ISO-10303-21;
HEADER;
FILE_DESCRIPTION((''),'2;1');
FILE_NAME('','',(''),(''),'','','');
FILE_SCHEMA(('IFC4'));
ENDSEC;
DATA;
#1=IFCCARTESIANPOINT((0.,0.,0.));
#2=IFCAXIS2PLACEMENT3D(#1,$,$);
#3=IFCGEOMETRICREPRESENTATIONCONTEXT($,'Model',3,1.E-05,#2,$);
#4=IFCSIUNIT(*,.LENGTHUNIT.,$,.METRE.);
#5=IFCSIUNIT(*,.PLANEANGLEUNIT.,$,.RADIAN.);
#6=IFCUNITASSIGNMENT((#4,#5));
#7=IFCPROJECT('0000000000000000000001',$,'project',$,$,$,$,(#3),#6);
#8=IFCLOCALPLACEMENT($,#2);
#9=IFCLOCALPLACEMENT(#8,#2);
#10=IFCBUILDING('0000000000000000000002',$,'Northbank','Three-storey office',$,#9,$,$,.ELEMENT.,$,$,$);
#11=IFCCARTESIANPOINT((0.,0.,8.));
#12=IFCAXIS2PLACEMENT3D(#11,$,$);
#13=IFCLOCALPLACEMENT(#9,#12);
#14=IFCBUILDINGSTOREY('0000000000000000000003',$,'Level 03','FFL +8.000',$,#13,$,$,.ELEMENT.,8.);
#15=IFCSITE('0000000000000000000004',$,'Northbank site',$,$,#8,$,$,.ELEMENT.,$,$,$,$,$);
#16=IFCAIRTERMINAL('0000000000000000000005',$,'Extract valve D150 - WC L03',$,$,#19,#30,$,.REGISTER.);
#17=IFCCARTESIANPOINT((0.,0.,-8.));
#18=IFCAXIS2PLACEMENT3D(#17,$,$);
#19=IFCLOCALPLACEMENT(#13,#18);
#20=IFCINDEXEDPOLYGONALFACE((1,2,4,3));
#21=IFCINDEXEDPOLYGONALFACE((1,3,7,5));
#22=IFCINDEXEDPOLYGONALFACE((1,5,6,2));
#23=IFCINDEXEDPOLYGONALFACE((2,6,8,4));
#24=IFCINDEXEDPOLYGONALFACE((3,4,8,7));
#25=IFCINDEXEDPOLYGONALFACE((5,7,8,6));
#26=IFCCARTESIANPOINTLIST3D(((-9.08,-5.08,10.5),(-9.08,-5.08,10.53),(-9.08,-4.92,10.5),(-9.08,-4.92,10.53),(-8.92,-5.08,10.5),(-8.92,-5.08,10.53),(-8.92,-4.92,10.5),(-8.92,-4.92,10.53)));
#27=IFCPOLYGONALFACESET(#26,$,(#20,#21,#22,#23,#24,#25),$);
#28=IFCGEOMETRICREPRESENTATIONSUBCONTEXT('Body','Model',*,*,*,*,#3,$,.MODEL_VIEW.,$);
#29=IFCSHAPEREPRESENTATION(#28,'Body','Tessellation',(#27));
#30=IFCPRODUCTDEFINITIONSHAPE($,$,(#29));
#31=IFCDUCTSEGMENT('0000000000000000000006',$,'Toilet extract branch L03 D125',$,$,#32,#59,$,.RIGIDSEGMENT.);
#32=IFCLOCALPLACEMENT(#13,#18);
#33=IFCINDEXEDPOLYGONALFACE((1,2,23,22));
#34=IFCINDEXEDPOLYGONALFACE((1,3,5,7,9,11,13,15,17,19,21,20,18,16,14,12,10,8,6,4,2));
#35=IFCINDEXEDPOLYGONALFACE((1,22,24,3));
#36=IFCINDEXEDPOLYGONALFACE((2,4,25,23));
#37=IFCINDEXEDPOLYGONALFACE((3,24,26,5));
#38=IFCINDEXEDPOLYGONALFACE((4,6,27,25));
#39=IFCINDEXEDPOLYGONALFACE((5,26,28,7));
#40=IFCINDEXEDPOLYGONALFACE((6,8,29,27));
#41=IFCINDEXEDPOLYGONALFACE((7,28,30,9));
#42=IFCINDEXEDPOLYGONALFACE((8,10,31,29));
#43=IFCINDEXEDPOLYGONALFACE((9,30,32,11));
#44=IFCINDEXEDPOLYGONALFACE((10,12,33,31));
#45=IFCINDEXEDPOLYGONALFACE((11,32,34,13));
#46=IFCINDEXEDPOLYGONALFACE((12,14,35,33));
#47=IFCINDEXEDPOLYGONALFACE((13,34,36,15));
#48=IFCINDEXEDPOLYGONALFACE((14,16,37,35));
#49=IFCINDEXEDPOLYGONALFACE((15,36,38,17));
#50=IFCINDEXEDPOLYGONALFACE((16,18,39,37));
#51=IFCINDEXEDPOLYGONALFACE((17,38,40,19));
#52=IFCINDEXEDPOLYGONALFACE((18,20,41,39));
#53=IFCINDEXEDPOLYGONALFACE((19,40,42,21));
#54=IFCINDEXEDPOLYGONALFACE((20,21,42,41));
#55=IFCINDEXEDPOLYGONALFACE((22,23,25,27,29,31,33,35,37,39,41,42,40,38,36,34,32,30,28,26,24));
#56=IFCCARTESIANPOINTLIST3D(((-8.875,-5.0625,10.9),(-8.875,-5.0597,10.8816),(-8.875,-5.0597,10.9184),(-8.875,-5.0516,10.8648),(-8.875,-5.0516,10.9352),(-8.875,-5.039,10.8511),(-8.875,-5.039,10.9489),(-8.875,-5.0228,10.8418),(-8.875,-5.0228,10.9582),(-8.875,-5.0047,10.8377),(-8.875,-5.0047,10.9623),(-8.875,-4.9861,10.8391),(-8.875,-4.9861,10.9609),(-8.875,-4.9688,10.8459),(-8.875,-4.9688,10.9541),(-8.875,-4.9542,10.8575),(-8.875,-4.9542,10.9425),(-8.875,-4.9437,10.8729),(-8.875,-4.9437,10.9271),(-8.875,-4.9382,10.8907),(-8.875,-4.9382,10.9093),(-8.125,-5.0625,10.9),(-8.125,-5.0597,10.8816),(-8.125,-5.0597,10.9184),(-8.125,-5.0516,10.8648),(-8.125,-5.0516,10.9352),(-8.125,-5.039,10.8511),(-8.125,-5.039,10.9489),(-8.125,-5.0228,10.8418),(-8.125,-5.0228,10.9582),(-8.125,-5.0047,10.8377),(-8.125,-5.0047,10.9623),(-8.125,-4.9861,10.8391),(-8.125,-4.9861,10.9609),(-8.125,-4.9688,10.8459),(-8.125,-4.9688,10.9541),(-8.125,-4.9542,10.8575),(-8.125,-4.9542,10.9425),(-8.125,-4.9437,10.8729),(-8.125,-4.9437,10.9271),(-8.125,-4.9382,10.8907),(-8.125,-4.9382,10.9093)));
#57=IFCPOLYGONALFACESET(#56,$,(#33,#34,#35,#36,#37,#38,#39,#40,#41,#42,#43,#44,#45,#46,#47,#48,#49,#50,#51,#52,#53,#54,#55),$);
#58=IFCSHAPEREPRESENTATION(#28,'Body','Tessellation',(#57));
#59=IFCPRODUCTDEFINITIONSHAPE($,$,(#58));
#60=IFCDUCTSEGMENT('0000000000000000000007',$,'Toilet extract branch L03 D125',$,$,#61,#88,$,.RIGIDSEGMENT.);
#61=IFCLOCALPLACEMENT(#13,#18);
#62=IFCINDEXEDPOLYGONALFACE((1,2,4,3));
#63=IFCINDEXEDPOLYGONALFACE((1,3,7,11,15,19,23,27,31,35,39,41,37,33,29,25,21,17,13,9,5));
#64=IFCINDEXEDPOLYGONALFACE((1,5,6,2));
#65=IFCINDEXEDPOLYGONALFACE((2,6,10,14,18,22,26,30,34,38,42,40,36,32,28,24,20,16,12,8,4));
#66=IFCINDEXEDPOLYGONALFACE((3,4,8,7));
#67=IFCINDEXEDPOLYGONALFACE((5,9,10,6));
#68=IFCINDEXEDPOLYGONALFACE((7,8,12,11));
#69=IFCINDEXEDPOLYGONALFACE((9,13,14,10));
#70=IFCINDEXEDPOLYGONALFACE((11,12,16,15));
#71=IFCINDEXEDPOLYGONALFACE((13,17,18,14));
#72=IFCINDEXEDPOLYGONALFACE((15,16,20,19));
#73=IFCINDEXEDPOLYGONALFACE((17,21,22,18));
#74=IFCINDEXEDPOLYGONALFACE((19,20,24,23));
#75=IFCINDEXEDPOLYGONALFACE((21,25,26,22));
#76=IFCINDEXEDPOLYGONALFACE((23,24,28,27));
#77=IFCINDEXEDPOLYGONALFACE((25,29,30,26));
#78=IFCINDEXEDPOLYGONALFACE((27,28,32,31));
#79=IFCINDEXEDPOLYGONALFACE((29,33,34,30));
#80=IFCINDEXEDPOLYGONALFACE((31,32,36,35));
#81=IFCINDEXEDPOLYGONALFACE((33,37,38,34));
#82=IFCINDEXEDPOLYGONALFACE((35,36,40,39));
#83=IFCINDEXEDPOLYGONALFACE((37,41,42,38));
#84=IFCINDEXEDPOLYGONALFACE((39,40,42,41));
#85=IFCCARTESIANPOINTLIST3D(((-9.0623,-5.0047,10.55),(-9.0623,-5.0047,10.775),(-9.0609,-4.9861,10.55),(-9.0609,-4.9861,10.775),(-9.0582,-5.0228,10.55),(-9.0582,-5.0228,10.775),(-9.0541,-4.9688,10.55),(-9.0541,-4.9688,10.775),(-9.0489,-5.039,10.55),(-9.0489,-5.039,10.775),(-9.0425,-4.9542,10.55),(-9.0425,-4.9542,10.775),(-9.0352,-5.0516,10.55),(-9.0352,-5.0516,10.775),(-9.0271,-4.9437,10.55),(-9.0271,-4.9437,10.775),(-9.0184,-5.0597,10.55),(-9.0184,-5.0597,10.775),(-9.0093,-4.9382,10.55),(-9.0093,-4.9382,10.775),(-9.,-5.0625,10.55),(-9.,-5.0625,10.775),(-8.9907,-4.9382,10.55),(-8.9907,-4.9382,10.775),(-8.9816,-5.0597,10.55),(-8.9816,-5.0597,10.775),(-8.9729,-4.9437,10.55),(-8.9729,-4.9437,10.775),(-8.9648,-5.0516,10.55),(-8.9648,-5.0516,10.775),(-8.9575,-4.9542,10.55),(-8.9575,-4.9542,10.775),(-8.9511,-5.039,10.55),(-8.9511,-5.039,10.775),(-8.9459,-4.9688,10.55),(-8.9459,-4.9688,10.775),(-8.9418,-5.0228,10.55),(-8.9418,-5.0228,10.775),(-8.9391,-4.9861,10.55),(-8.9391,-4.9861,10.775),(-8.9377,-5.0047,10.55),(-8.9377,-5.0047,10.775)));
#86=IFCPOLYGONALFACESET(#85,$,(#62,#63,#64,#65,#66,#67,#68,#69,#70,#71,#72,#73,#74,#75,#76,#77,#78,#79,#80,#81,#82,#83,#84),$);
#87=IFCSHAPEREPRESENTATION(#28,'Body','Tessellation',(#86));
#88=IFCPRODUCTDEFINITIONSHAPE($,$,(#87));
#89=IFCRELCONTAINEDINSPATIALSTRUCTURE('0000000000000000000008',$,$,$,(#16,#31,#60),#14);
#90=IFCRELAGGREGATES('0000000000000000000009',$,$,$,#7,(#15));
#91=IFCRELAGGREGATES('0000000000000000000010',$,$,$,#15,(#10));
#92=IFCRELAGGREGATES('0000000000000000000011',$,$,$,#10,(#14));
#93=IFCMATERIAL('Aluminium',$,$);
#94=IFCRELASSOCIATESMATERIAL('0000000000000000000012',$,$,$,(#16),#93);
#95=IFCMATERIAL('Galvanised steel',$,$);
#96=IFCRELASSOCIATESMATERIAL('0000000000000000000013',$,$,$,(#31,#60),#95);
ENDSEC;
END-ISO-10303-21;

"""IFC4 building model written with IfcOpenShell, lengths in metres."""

from ifc_helpers import new_model, si_unit, frame, origin, place, context, subcontext, project, spatial, rectangle, circle, extrude, material, element, save


model = new_model("IFC4")

# Units and contexts
model_context = context("Model", 3, precision=1e-05, world=origin())
body_context = subcontext(model_context, "Body", "Model", "MODEL_VIEW")
ifc_project = project(units=[si_unit("LENGTHUNIT", "METRE"), si_unit("PLANEANGLEUNIT", "RADIAN")], contexts=[model_context])

# Site, building, storey
site_placement = place(None, origin())
site = spatial("IfcSite", under=ifc_project, at=site_placement, Name="Northbank site", CompositionType="ELEMENT")
building_placement = place(site_placement, origin())
building = spatial("IfcBuilding", under=site, at=building_placement, Name="Northbank", Description="Three-storey office", CompositionType="ELEMENT")
storey_placement = place(building_placement, frame((0.0, 0.0, 8.0)))
storey = spatial("IfcBuildingStorey", under=building, at=storey_placement, Name="Level 03", Description="FFL +8.000", CompositionType="ELEMENT", Elevation=8.0)

# Shared definitions
ifc_material_1 = material(Name="Galvanised steel")

# Shared definitions
ifc_material_2 = material(Name="Aluminium")

# Air terminal
air_terminal_1_placement = place(storey_placement, frame((0.0, 0.0, -8.0)))
element("IfcAirTerminal", 1, at=air_terminal_1_placement, inside=storey, material=ifc_material_2, Name="Extract valve D150 - WC L03", PredefinedType="REGISTER", context=body_context, shape_type="SweptSolid", body=[
    extrude(rectangle(XDim=0.16, YDim=0.16), frame((-9.0, -5.0, 10.5)), (0.0, 0.0, 1.0), 0.03),
])

# Duct segments
duct_segment_1_placement = place(storey_placement, frame((0.0, 0.0, -8.0)))
element("IfcDuctSegment", 2, at=duct_segment_1_placement, inside=storey, material=ifc_material_1, Name="Toilet extract branch L03 D125", PredefinedType="RIGIDSEGMENT", context=body_context, shape_type="SweptSolid", body=[
    extrude(circle(Radius=0.0625), frame((-8.125, -5.0, 10.9), z_axis=(-1.0, 0.0, 0.0), x_axis=(0.0, -1.0, 0.0)), (0.0, 0.0, 1.0), 0.75),
])
duct_segment_2_placement = place(storey_placement, frame((0.0, 0.0, -8.0)))
element("IfcDuctSegment", 3, at=duct_segment_2_placement, inside=storey, material=ifc_material_1, Name="Toilet extract branch L03 D125", PredefinedType="RIGIDSEGMENT", context=body_context, shape_type="SweptSolid", body=[
    extrude(circle(Radius=0.0625), frame((-9.0, -5.0, 10.775), z_axis=(0.0, 0.0, -1.0), x_axis=(0.0, -1.0, 0.0)), (0.0, 0.0, 1.0), 0.225),
])

save(model, "model.ifc")
